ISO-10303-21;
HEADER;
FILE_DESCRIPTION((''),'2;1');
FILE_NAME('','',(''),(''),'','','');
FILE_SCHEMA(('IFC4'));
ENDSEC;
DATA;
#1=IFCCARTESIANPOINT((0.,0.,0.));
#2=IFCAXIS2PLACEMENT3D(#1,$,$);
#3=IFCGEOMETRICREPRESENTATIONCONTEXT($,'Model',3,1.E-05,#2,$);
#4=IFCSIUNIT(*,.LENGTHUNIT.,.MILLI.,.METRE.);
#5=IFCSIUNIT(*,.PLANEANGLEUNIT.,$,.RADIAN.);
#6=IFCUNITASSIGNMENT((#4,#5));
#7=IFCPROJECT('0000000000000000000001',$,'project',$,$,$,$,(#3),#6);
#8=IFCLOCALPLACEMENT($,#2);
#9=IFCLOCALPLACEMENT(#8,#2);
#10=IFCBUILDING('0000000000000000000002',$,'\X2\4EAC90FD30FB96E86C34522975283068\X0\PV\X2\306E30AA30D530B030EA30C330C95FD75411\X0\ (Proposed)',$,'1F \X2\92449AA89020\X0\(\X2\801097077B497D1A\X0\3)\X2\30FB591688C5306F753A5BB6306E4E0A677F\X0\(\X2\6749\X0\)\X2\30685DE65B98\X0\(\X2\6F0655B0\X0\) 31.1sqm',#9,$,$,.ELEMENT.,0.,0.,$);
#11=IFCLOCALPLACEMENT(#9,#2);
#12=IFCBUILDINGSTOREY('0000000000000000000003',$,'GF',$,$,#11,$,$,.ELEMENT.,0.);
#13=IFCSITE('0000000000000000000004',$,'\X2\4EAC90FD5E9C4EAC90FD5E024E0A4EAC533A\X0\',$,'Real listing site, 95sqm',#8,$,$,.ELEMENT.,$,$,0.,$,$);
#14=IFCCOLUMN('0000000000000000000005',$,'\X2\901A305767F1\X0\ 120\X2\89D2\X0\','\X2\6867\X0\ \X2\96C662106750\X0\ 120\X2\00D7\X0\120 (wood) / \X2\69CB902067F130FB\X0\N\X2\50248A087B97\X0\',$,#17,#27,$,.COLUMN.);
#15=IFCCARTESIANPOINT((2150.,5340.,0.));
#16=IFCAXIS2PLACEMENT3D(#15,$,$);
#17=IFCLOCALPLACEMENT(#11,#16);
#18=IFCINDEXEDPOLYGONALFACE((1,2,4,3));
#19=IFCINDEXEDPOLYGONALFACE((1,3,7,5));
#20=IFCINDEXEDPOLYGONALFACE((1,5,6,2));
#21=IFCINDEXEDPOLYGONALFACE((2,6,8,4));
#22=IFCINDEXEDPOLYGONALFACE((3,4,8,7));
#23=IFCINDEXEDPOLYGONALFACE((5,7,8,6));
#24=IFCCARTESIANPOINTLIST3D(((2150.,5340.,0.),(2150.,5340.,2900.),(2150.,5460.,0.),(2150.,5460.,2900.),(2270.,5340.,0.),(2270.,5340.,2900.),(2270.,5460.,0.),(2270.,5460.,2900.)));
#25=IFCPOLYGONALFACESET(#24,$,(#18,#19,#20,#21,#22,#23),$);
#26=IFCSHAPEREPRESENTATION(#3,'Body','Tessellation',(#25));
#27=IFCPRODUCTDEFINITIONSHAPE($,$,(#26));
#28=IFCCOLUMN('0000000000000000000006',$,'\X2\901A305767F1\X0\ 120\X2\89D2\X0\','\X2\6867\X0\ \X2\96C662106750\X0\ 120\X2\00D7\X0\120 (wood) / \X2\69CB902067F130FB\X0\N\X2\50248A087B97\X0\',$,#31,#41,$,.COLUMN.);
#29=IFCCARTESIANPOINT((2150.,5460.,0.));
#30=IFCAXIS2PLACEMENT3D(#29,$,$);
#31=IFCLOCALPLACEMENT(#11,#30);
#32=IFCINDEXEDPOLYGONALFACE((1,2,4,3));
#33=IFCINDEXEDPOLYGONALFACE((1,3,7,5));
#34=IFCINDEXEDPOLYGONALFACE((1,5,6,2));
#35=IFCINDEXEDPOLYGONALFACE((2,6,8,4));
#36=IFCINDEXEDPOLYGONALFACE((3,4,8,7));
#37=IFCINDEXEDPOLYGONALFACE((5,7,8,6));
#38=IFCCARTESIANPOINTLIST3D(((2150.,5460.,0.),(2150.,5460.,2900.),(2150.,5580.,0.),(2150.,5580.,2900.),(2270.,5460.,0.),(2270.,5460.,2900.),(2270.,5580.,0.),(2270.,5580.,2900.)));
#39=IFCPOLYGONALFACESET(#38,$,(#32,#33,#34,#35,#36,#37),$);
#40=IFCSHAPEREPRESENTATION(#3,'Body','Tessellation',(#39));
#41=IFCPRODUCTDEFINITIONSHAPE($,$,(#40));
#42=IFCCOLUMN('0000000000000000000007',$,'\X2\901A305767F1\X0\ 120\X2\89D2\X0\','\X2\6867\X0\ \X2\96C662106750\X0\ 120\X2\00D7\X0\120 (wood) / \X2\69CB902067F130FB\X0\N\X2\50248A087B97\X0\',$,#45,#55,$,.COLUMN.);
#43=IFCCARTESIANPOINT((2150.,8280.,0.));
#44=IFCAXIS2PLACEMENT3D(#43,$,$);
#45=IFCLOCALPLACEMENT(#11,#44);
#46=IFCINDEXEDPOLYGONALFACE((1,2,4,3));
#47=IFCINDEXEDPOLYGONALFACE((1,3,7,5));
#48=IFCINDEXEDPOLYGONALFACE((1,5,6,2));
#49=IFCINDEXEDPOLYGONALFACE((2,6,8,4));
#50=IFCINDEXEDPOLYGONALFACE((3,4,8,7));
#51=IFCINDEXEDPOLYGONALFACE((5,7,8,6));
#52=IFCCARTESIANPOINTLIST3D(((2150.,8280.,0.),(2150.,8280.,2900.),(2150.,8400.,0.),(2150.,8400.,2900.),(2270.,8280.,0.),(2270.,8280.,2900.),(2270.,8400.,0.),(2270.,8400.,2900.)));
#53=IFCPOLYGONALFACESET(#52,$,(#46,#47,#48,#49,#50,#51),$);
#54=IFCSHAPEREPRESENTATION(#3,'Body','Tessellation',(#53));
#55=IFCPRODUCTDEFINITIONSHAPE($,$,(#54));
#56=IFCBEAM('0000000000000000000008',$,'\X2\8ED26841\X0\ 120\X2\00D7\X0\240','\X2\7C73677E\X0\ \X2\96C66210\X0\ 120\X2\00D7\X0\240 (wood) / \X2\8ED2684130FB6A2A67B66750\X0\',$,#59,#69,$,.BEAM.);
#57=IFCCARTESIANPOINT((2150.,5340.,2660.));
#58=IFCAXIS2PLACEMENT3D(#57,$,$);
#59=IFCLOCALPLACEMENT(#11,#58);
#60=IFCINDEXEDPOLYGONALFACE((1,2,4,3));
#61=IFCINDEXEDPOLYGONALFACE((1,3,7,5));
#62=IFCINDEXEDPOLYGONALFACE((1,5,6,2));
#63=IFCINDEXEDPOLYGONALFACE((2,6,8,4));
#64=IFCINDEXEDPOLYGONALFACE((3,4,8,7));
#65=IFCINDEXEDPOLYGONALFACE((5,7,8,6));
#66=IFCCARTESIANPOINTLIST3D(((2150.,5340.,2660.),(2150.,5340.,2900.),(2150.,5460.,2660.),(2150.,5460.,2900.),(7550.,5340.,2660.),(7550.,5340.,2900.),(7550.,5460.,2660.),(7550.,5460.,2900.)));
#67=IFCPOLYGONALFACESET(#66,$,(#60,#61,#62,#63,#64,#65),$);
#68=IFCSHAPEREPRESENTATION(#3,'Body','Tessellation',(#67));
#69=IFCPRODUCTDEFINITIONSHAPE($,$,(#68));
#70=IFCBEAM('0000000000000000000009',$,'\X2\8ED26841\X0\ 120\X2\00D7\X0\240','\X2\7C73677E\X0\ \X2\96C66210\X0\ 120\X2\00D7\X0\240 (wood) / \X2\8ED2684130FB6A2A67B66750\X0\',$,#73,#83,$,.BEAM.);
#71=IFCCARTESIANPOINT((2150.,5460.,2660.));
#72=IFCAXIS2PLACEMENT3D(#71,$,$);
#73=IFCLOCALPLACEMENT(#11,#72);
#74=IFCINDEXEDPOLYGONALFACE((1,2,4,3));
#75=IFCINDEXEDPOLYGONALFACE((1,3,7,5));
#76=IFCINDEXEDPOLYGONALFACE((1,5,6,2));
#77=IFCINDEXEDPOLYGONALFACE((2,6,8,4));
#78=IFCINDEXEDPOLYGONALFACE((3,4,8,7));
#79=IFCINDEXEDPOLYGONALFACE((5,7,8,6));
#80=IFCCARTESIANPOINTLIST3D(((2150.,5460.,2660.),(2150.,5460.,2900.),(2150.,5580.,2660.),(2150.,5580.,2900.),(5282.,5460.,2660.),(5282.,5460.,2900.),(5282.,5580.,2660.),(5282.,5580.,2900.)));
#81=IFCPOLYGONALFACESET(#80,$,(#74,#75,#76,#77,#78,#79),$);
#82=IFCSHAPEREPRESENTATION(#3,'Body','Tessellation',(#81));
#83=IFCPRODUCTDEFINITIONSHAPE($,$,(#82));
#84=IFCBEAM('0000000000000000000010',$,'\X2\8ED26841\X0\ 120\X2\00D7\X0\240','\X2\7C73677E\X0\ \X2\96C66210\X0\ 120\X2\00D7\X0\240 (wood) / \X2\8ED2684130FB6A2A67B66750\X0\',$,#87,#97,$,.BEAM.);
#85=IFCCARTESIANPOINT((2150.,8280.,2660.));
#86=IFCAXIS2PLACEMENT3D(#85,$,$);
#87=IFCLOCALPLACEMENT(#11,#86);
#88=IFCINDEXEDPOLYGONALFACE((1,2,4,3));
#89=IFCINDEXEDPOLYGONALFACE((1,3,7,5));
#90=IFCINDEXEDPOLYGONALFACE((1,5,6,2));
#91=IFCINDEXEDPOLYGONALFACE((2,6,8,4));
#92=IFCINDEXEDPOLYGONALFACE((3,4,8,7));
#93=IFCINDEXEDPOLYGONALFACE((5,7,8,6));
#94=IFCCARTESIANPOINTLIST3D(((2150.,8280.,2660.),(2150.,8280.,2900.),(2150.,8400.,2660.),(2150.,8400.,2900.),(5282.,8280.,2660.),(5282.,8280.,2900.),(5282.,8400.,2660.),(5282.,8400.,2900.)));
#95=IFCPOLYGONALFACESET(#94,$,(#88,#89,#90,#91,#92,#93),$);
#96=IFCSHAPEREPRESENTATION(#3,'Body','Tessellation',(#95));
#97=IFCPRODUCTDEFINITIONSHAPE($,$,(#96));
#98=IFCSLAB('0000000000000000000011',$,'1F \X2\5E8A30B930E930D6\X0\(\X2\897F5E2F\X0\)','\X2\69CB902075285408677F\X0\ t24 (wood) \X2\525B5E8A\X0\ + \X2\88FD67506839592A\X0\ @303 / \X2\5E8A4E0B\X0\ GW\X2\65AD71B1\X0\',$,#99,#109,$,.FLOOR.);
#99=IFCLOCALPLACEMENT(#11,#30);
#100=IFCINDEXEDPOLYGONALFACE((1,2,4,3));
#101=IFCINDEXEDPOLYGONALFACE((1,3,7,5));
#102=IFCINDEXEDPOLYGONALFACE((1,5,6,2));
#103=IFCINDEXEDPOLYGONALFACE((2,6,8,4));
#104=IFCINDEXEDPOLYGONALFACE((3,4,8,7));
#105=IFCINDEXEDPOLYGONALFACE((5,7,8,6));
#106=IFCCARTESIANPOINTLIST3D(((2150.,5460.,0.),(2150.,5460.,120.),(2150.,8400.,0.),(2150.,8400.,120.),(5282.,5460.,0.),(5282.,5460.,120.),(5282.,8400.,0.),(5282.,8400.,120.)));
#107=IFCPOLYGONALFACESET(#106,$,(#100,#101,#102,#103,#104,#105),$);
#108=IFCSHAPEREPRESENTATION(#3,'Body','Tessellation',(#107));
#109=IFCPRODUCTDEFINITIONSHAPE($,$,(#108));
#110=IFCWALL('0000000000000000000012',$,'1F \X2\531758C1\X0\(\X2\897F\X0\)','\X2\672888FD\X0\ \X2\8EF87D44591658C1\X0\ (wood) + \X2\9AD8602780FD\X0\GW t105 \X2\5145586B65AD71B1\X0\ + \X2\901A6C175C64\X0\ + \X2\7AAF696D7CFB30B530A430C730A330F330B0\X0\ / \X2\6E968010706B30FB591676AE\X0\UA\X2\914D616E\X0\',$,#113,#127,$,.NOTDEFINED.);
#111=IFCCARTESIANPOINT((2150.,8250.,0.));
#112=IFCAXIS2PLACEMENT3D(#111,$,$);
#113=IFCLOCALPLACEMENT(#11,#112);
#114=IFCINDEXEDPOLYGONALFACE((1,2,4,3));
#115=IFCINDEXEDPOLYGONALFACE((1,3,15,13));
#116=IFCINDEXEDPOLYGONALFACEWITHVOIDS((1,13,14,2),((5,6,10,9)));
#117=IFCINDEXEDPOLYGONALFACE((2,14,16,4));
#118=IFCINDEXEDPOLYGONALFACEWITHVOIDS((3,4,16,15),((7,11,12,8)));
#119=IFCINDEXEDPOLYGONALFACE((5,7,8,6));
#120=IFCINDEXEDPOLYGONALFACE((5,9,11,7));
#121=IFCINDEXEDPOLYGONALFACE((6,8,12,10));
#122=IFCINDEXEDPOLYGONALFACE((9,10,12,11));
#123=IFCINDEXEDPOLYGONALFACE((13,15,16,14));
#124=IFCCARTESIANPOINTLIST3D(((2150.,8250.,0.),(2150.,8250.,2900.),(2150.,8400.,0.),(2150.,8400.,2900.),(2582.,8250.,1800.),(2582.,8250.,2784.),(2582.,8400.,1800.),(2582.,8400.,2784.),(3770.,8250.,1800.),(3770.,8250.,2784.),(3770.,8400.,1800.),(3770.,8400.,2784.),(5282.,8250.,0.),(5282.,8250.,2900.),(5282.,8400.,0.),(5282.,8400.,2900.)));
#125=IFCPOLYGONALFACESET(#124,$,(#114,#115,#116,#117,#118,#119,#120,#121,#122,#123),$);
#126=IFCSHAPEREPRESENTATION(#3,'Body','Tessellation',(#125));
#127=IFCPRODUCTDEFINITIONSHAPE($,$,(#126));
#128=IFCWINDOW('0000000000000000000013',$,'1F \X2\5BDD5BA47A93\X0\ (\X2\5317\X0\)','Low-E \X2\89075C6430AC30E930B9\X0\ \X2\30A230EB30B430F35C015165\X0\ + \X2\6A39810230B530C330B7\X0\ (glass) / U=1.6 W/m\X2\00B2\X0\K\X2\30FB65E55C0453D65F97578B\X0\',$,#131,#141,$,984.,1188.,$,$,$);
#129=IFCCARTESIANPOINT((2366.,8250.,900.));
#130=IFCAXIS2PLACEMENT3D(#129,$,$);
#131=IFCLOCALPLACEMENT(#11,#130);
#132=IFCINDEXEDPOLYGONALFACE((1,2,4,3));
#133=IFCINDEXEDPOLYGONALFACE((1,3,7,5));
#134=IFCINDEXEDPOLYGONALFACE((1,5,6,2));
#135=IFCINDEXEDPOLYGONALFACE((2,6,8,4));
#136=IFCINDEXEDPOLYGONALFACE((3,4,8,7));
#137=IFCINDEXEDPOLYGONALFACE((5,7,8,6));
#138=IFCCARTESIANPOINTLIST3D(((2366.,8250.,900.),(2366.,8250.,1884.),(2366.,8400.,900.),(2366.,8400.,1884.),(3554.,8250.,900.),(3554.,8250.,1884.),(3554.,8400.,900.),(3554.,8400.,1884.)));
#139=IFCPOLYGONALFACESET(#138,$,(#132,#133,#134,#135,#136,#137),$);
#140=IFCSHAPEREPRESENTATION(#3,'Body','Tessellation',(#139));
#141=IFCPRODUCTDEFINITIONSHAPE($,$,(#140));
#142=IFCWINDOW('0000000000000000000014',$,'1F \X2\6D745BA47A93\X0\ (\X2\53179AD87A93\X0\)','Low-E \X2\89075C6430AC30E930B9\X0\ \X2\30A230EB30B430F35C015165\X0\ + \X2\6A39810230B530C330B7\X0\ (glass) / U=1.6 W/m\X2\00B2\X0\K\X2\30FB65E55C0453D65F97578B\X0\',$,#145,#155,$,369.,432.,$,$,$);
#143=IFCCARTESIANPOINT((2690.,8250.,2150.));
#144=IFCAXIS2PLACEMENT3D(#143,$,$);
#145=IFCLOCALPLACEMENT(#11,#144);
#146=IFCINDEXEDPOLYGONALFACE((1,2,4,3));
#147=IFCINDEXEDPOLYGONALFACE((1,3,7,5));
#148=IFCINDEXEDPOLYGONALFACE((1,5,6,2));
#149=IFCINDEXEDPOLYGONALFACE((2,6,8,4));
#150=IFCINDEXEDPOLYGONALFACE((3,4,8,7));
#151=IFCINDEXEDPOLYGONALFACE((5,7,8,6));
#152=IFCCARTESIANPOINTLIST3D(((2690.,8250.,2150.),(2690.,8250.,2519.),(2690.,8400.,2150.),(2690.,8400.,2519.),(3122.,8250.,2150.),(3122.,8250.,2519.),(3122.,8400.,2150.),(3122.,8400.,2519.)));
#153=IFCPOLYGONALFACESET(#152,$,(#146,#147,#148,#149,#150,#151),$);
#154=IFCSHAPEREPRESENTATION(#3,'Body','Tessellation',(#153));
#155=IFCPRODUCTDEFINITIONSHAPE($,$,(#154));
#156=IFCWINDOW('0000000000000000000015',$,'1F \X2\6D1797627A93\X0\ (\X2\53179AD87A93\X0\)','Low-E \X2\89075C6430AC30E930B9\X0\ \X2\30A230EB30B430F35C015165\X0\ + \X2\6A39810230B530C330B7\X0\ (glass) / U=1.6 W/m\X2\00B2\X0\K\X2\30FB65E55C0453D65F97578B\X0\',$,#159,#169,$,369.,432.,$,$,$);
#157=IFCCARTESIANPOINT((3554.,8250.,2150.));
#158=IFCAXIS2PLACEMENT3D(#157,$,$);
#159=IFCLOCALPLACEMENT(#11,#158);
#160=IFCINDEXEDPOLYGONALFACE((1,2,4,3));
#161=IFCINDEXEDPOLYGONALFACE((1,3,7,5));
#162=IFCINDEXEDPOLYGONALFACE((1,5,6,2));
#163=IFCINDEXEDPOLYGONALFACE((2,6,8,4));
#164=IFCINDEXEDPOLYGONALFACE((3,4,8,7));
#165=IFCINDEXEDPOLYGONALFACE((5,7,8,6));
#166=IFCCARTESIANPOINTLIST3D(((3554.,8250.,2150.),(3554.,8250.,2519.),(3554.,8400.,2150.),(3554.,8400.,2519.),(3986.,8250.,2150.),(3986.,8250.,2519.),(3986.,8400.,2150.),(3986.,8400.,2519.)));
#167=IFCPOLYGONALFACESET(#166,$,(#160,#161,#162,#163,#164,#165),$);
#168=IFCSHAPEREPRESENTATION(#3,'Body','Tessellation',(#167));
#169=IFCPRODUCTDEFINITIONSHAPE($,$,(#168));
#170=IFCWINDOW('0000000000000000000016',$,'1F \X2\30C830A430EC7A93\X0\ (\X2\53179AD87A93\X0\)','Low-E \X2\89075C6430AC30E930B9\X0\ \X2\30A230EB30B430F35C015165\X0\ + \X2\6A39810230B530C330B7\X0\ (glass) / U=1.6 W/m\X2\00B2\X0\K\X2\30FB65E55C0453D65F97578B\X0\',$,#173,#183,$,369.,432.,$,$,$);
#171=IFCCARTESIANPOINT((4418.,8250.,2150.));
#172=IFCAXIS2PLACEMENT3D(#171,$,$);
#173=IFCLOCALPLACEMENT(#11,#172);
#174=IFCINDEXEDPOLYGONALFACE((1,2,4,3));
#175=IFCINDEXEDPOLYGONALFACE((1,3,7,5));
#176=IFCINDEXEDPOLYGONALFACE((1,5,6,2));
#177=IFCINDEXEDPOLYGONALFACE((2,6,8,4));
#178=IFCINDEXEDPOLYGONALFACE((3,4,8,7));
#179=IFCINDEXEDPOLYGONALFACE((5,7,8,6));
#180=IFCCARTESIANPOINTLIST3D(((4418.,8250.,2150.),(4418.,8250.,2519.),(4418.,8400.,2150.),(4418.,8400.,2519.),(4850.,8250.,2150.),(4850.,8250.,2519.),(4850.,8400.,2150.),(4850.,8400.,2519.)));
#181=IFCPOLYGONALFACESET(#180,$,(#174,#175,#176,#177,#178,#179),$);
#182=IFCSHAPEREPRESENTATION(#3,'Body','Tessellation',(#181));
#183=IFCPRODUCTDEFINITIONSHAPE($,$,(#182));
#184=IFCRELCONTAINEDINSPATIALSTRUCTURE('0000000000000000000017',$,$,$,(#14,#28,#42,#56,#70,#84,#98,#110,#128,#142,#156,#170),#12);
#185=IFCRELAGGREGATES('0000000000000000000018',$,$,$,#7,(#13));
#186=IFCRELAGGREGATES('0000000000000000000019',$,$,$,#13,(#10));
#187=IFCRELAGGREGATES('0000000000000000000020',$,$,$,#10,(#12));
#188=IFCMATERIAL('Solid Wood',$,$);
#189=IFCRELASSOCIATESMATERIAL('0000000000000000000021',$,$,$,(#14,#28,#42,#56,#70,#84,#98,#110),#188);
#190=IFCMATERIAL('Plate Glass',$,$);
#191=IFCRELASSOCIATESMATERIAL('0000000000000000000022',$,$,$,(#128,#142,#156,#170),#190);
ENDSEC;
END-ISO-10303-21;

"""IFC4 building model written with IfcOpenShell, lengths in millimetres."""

from ifc_helpers import new_model, si_unit, frame, frame_2d, origin, place, context, project, spatial, rectangle, extrude, material, element, fill, save


model = new_model("IFC4")

# Units and contexts
model_context = context("Model", 3, precision=1e-05, world=origin())
ifc_project = project(units=[si_unit("LENGTHUNIT", "METRE", prefix="MILLI"), si_unit("PLANEANGLEUNIT", "RADIAN")], contexts=[model_context])

# Site, building, storey
site_placement = place(None, origin())
site = spatial("IfcSite", under=ifc_project, at=site_placement, Name="京都府京都市上京区", ObjectType="Real listing site, 95sqm", CompositionType="ELEMENT", RefElevation=0.0)
building_placement = place(site_placement, origin())
building = spatial("IfcBuilding", under=site, at=building_placement, Name="京都・雨水利用とPVのオフグリッド志向 (Proposed)", ObjectType="1F 鉄骨造(耐震等級3)・外装は町家の上板(杉)と左官(漆喰) 31.1sqm", CompositionType="ELEMENT", ElevationOfRefHeight=0.0, ElevationOfTerrain=0.0)
storey_placement = place(building_placement, origin())
storey = spatial("IfcBuildingStorey", under=building, at=storey_placement, Name="GF", CompositionType="ELEMENT", Elevation=0.0)

# Columns
ifc_material_1 = material(Name="Solid Wood")
column_1_placement = place(storey_placement, frame((2150.0, 5340.0, 0.0)))
element("IfcColumn", 1, at=column_1_placement, inside=storey, material=ifc_material_1, Name="通し柱 120角", Description="桧 集成材 120×120 (wood) / 構造柱・N値計算", PredefinedType="COLUMN", context=model_context, shape_type="SweptSolid", body=[
    extrude(rectangle(XDim=120.0, YDim=120.0, at=frame_2d((60.0, 60.0))), frame((2150.0, 5340.0, 0.0)), (0.0, 0.0, 1.0), 2900.0),
])
column_2_placement = place(storey_placement, frame((2150.0, 5460.0, 0.0)))
element("IfcColumn", 2, at=column_2_placement, inside=storey, material=ifc_material_1, Name="通し柱 120角", Description="桧 集成材 120×120 (wood) / 構造柱・N値計算", PredefinedType="COLUMN", context=model_context, shape_type="SweptSolid", body=[
    extrude(rectangle(XDim=120.0, YDim=120.0, at=frame_2d((60.0, 60.0))), frame((2150.0, 5460.0, 0.0)), (0.0, 0.0, 1.0), 2900.0),
])
column_3_placement = place(storey_placement, frame((2150.0, 8280.0, 0.0)))
element("IfcColumn", 3, at=column_3_placement, inside=storey, material=ifc_material_1, Name="通し柱 120角", Description="桧 集成材 120×120 (wood) / 構造柱・N値計算", PredefinedType="COLUMN", context=model_context, shape_type="SweptSolid", body=[
    extrude(rectangle(XDim=120.0, YDim=120.0, at=frame_2d((60.0, 60.0))), frame((2150.0, 8280.0, 0.0)), (0.0, 0.0, 1.0), 2900.0),
])

# Beams
beam_1_placement = place(storey_placement, frame((2150.0, 5340.0, 2660.0)))
element("IfcBeam", 4, at=beam_1_placement, inside=storey, material=ifc_material_1, Name="軒桁 120×240", Description="米松 集成 120×240 (wood) / 軒桁・横架材", PredefinedType="BEAM", context=model_context, shape_type="SweptSolid", body=[
    extrude(rectangle(XDim=5400.0, YDim=120.0, at=frame_2d((2700.0, 60.0))), frame((2150.0, 5340.0, 2660.0)), (0.0, 0.0, 1.0), 240.0),
])
beam_2_placement = place(storey_placement, frame((2150.0, 5460.0, 2660.0)))
element("IfcBeam", 5, at=beam_2_placement, inside=storey, material=ifc_material_1, Name="軒桁 120×240", Description="米松 集成 120×240 (wood) / 軒桁・横架材", PredefinedType="BEAM", context=model_context, shape_type="SweptSolid", body=[
    extrude(rectangle(XDim=3132.0, YDim=120.0, at=frame_2d((1566.0, 60.0))), frame((2150.0, 5460.0, 2660.0)), (0.0, 0.0, 1.0), 240.0),
])
beam_3_placement = place(storey_placement, frame((2150.0, 8280.0, 2660.0)))
element("IfcBeam", 6, at=beam_3_placement, inside=storey, material=ifc_material_1, Name="軒桁 120×240", Description="米松 集成 120×240 (wood) / 軒桁・横架材", PredefinedType="BEAM", context=model_context, shape_type="SweptSolid", body=[
    extrude(rectangle(XDim=3132.0, YDim=120.0, at=frame_2d((1566.0, 60.0))), frame((2150.0, 8280.0, 2660.0)), (0.0, 0.0, 1.0), 240.0),
])

# Slab
slab_placement = place(storey_placement, frame((2150.0, 5460.0, 0.0)))
element("IfcSlab", 7, at=slab_placement, inside=storey, material=ifc_material_1, Name="1F 床スラブ(西帯)", Description="構造用合板 t24 (wood) 剛床 + 製材根太 @303 / 床下 GW断熱", PredefinedType="FLOOR", context=model_context, shape_type="SweptSolid", body=[
    extrude(rectangle(XDim=3132.0, YDim=2940.0, at=frame_2d((1566.0, 1470.0))), frame((2150.0, 5460.0, 0.0)), (0.0, 0.0, 1.0), 120.0),
])

# Wall, openings, windows
wall_1_placement = place(storey_placement, frame((2150.0, 8250.0, 0.0)))
wall_1 = element("IfcWall", 8, at=wall_1_placement, inside=storey, material=ifc_material_1, Name="1F 北壁(西)", Description="木製 軸組外壁 (wood) + 高性能GW t105 充填断熱 + 通気層 + 窯業系サイディング / 準耐火・外皮UA配慮", PredefinedType="NOTDEFINED", context=model_context, shape_type="SweptSolid", body=[
    extrude(rectangle(XDim=3132.0, YDim=150.0, at=frame_2d((1566.0, 75.0))), frame((2150.0, 8250.0, 0.0)), (0.0, 0.0, 1.0), 2900.0),
])
opening_1_placement = place(storey_placement, frame((2366.0, 8250.0, 900.0)))
opening_1 = element("IfcOpeningElement", 9, at=opening_1_placement, cuts=wall_1, PredefinedType="NOTDEFINED", context=model_context, shape_type="SweptSolid", body=[
    extrude(rectangle(XDim=1188.0, YDim=150.0, at=frame_2d((594.0, 75.0))), frame((2366.0, 8250.0, 900.0)), (0.0, 0.0, 1.0), 984.0),
])
opening_2_placement = place(storey_placement, frame((2690.0, 8250.0, 2150.0)))
opening_2 = element("IfcOpeningElement", 10, at=opening_2_placement, cuts=wall_1, PredefinedType="NOTDEFINED", context=model_context, shape_type="SweptSolid", body=[
    extrude(rectangle(XDim=432.0, YDim=150.0, at=frame_2d((216.0, 75.0))), frame((2690.0, 8250.0, 2150.0)), (0.0, 0.0, 1.0), 369.0),
])
opening_3_placement = place(storey_placement, frame((3554.0, 8250.0, 2150.0)))
opening_3 = element("IfcOpeningElement", 11, at=opening_3_placement, cuts=wall_1, PredefinedType="NOTDEFINED", context=model_context, shape_type="SweptSolid", body=[
    extrude(rectangle(XDim=432.0, YDim=150.0, at=frame_2d((216.0, 75.0))), frame((3554.0, 8250.0, 2150.0)), (0.0, 0.0, 1.0), 369.0),
])
opening_4_placement = place(storey_placement, frame((4418.0, 8250.0, 2150.0)))
opening_4 = element("IfcOpeningElement", 12, at=opening_4_placement, cuts=wall_1, PredefinedType="NOTDEFINED", context=model_context, shape_type="SweptSolid", body=[
    extrude(rectangle(XDim=432.0, YDim=150.0, at=frame_2d((216.0, 75.0))), frame((4418.0, 8250.0, 2150.0)), (0.0, 0.0, 1.0), 369.0),
])
ifc_material_2 = material(Name="Plate Glass")
window_1_placement = place(storey_placement, frame((2366.0, 8250.0, 900.0)))
window_1 = element("IfcWindow", 13, at=window_1_placement, inside=storey, material=ifc_material_2, Name="1F 寝室窓 (北)", Description="Low-E 複層ガラス アルゴン封入 + 樹脂サッシ (glass) / U=1.6 W/m²K・日射取得型", OverallHeight=984.0, OverallWidth=1188.0, context=model_context, shape_type="SweptSolid", body=[
    extrude(rectangle(XDim=1188.0, YDim=150.0, at=frame_2d((594.0, 75.0))), frame((2366.0, 8250.0, 900.0)), (0.0, 0.0, 1.0), 984.0),
])
fill(opening_1, window_1)
window_2_placement = place(storey_placement, frame((2690.0, 8250.0, 2150.0)))
window_2 = element("IfcWindow", 14, at=window_2_placement, inside=storey, material=ifc_material_2, Name="1F 浴室窓 (北高窓)", Description="Low-E 複層ガラス アルゴン封入 + 樹脂サッシ (glass) / U=1.6 W/m²K・日射取得型", OverallHeight=369.0, OverallWidth=432.0, context=model_context, shape_type="SweptSolid", body=[
    extrude(rectangle(XDim=432.0, YDim=150.0, at=frame_2d((216.0, 75.0))), frame((2690.0, 8250.0, 2150.0)), (0.0, 0.0, 1.0), 369.0),
])
fill(opening_2, window_2)
window_3_placement = place(storey_placement, frame((3554.0, 8250.0, 2150.0)))
window_3 = element("IfcWindow", 15, at=window_3_placement, inside=storey, material=ifc_material_2, Name="1F 洗面窓 (北高窓)", Description="Low-E 複層ガラス アルゴン封入 + 樹脂サッシ (glass) / U=1.6 W/m²K・日射取得型", OverallHeight=369.0, OverallWidth=432.0, context=model_context, shape_type="SweptSolid", body=[
    extrude(rectangle(XDim=432.0, YDim=150.0, at=frame_2d((216.0, 75.0))), frame((3554.0, 8250.0, 2150.0)), (0.0, 0.0, 1.0), 369.0),
])
fill(opening_3, window_3)
window_4_placement = place(storey_placement, frame((4418.0, 8250.0, 2150.0)))
window_4 = element("IfcWindow", 16, at=window_4_placement, inside=storey, material=ifc_material_2, Name="1F トイレ窓 (北高窓)", Description="Low-E 複層ガラス アルゴン封入 + 樹脂サッシ (glass) / U=1.6 W/m²K・日射取得型", OverallHeight=369.0, OverallWidth=432.0, context=model_context, shape_type="SweptSolid", body=[
    extrude(rectangle(XDim=432.0, YDim=150.0, at=frame_2d((216.0, 75.0))), frame((4418.0, 8250.0, 2150.0)), (0.0, 0.0, 1.0), 369.0),
])
fill(opening_4, window_4)

save(model, "model.ifc")
